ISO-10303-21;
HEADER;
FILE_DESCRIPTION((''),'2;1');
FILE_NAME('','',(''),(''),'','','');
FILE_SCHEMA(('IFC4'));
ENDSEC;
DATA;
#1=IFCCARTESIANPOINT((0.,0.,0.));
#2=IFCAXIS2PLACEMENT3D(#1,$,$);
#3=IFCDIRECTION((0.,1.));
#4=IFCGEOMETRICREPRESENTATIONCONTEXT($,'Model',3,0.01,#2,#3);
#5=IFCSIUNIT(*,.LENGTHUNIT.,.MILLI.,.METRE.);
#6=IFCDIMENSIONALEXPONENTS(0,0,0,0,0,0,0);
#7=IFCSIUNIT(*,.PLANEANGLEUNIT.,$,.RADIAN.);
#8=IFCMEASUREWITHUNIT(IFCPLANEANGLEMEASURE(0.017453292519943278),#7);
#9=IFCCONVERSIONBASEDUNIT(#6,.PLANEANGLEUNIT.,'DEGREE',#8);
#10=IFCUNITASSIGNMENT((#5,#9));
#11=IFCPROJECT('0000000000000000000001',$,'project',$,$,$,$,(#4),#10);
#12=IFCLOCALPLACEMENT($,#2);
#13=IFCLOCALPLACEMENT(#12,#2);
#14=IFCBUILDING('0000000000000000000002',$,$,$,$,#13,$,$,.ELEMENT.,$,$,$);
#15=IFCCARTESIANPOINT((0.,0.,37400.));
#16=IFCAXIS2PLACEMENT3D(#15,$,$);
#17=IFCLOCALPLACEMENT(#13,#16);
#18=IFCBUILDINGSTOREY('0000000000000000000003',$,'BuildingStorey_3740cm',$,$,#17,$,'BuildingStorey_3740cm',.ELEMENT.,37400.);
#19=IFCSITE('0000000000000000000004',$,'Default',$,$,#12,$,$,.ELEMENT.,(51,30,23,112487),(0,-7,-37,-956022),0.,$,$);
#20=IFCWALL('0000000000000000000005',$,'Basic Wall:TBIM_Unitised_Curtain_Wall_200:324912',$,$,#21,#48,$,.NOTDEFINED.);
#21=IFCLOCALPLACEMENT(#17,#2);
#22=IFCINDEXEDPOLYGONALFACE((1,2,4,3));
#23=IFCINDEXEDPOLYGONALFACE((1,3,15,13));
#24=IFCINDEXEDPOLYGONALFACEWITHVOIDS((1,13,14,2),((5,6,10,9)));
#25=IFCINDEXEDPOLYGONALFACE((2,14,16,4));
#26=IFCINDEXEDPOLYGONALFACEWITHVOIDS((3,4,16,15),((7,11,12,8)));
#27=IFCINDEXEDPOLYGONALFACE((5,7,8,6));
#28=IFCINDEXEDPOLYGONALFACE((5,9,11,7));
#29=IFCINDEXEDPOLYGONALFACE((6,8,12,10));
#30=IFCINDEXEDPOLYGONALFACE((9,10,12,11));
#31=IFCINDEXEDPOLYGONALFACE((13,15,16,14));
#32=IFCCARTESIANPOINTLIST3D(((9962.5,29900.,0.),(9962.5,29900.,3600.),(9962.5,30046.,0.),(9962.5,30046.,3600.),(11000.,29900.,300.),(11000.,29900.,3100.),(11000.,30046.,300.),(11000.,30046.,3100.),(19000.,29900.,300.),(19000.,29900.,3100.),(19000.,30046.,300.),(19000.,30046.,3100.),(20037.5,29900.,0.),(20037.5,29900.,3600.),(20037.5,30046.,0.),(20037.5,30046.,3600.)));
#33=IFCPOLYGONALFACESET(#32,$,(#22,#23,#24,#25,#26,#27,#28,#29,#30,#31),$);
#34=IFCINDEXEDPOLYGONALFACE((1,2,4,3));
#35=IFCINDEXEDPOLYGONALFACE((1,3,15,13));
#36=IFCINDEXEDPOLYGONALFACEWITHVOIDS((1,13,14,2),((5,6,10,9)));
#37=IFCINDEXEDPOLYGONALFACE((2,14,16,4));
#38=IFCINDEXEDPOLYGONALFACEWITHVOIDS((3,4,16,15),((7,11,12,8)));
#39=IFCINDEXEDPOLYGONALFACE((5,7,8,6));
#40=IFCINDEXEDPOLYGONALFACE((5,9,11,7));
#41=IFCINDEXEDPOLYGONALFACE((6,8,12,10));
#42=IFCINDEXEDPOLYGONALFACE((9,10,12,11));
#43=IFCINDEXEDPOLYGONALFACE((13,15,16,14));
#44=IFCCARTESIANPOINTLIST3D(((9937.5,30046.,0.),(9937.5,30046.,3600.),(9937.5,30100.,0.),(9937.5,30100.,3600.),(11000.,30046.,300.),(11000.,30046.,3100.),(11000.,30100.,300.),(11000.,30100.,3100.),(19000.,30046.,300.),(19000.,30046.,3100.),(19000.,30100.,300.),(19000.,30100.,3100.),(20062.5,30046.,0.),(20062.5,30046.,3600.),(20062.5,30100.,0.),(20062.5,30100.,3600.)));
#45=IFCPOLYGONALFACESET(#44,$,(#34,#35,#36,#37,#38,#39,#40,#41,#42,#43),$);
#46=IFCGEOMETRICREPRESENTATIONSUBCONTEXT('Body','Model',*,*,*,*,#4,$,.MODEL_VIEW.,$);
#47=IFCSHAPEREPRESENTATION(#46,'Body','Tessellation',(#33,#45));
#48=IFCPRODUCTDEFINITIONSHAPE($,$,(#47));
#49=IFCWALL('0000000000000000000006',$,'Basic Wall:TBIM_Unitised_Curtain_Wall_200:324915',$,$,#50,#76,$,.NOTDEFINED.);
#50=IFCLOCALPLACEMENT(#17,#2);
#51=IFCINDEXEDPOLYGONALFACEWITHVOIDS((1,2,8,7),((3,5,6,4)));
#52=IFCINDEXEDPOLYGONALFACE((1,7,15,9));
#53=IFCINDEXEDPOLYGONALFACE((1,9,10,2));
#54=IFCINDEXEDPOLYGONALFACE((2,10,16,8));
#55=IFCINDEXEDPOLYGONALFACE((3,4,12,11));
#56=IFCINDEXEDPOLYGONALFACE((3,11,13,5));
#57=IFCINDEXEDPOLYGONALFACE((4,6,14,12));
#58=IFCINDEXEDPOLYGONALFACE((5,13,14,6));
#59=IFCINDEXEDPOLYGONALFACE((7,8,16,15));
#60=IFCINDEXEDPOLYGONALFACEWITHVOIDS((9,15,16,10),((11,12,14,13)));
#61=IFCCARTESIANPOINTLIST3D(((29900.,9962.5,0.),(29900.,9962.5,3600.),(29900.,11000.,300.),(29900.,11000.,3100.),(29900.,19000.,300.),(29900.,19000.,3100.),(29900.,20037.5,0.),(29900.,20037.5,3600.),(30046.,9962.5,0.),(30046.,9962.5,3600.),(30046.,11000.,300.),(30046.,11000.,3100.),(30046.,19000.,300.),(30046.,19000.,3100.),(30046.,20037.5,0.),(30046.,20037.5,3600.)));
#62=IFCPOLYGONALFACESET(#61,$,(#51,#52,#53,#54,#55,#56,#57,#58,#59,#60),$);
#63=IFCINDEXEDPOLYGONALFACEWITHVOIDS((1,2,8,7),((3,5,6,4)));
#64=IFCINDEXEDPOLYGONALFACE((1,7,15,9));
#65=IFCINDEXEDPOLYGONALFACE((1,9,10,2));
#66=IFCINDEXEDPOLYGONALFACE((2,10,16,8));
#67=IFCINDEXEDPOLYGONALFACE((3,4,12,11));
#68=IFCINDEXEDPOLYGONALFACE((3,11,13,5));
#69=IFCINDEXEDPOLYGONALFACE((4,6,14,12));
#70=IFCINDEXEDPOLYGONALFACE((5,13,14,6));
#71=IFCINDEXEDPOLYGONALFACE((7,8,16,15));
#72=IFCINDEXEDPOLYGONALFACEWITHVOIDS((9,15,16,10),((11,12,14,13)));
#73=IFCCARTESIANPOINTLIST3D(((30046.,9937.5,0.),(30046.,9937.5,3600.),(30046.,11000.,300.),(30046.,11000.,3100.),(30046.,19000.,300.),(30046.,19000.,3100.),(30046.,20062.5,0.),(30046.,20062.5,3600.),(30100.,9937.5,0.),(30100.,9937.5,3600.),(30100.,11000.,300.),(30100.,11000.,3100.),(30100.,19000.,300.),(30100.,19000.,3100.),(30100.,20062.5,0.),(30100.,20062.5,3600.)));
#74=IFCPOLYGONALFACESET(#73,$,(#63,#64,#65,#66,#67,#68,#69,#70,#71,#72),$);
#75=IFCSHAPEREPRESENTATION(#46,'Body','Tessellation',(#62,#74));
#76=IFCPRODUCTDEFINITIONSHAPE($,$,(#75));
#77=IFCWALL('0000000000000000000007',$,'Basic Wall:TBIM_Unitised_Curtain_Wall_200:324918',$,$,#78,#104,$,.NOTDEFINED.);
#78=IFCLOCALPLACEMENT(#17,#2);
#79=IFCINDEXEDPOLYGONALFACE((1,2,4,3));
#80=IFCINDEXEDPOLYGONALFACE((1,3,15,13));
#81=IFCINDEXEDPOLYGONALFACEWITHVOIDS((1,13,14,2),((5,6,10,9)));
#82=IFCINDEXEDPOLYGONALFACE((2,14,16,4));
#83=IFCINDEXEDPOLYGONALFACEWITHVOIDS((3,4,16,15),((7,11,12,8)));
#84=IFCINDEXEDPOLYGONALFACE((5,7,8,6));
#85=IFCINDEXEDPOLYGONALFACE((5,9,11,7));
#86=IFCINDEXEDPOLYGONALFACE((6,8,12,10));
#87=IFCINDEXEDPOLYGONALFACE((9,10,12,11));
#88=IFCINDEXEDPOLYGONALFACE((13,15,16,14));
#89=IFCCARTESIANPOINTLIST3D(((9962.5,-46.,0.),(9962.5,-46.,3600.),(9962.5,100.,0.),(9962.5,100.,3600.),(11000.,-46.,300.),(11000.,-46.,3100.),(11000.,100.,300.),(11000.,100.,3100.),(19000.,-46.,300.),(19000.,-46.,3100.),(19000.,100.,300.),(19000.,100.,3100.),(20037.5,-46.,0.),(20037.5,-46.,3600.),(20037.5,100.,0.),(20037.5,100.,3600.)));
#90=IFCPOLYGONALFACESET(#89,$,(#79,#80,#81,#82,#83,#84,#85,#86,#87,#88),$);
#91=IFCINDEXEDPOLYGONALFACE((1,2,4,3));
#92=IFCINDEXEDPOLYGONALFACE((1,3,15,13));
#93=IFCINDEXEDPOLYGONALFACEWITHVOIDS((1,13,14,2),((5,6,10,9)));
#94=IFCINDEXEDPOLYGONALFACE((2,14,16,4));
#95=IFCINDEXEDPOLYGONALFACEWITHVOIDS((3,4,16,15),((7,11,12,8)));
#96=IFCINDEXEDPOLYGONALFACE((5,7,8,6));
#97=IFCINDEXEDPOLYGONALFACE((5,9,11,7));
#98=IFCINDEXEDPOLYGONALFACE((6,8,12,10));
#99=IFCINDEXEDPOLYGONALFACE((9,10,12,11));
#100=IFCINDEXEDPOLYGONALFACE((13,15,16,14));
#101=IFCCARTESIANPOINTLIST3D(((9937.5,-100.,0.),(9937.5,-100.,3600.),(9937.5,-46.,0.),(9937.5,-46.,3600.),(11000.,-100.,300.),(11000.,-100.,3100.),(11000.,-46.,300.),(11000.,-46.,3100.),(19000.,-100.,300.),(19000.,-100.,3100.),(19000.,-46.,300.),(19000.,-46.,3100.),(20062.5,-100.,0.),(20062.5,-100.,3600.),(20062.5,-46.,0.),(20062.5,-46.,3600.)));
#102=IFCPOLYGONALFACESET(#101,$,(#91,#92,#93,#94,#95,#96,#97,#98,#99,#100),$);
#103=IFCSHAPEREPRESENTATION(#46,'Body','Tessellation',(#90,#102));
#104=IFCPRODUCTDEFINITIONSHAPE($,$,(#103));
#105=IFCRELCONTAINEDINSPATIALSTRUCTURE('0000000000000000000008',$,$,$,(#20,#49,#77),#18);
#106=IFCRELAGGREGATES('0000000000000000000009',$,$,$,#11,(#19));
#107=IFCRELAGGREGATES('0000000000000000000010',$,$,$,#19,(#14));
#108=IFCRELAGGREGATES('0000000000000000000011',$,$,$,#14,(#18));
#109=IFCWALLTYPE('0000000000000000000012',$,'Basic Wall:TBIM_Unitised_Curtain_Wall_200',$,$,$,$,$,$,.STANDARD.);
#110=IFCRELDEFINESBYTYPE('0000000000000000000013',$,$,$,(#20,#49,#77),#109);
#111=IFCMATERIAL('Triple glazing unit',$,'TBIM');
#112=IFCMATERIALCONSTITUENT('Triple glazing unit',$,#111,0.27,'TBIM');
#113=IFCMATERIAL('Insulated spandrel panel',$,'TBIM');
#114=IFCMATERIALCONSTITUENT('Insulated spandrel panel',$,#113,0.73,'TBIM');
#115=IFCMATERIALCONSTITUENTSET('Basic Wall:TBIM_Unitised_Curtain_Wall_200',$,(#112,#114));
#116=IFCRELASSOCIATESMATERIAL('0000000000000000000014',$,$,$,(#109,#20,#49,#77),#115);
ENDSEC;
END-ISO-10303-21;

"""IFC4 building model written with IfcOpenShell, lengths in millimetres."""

from ifc_helpers import new_model, entity, si_unit, converted_unit, direction, frame, origin, place, context, subcontext, project, spatial, indexed_curve, outline, extrude, material, constituent, constituent_set, type_object, element, save


model = new_model("IFC4")

# Units and contexts
model_context = context("Model", 3, precision=0.01, world=origin(), true_north=direction((0.0, 1.0)))
body_context = subcontext(model_context, "Body", "Model", "MODEL_VIEW")
ifc_project = project(units=[si_unit("LENGTHUNIT", "METRE", prefix="MILLI"), converted_unit("PLANEANGLEUNIT", "DEGREE", entity("IfcPlaneAngleMeasure", 0.017453292519943278), si_unit("PLANEANGLEUNIT", "RADIAN"), dimensions=[0, 0, 0, 0, 0, 0, 0])], contexts=[model_context])

# Site, building, storey
site_placement = place(None, origin())
site = spatial("IfcSite", under=ifc_project, at=site_placement, Name="Default", CompositionType="ELEMENT", RefLatitude=(51, 30, 23, 112487), RefLongitude=(0, -7, -37, -956022), RefElevation=0.0)
building_placement = place(site_placement, origin())
building = spatial("IfcBuilding", under=site, at=building_placement, CompositionType="ELEMENT")
storey_placement = place(building_placement, frame((0.0, 0.0, 37400.0)))
storey = spatial("IfcBuildingStorey", under=building, at=storey_placement, Name="BuildingStorey_3740cm", LongName="BuildingStorey_3740cm", CompositionType="ELEMENT", Elevation=37400.0)

# Walls, openings
ifc_material_1 = material(Name="Triple glazing unit", Category="TBIM")
ifc_constituent_1 = constituent(ifc_material_1, Name="Triple glazing unit", Category="TBIM", fraction=0.27)
ifc_material_2 = material(Name="Insulated spandrel panel", Category="TBIM")
ifc_constituent_2 = constituent(ifc_material_2, Name="Insulated spandrel panel", Category="TBIM", fraction=0.73)
ifc_constituent_set_1 = constituent_set(constituents=[ifc_constituent_1, ifc_constituent_2], Name="Basic Wall:TBIM_Unitised_Curtain_Wall_200")
wall_type_1 = type_object("IfcWallType", Name="Basic Wall:TBIM_Unitised_Curtain_Wall_200", PredefinedType="STANDARD", material=ifc_constituent_set_1)
wall_1_placement = place(storey_placement, frame((9937.5, 30000.0, 0.0)))
wall_1 = element("IfcWall", 1, at=wall_1_placement, inside=storey, type_object=wall_type_1, material=ifc_constituent_set_1, Name="Basic Wall:TBIM_Unitised_Curtain_Wall_200:324912", PredefinedType="NOTDEFINED", context=body_context, shape_type="SweptSolid", body=[
    extrude(outline(indexed_curve([(-1800.0, -5037.5), (1800.0, -5037.5), (1800.0, -4937.5), (1800.0, 4937.5), (1800.0, 5037.5), (-1800.0, 5037.5), (-1800.0, 4937.5), (-1800.0, -4937.5), (-1800.0, -5037.5)], self_intersect=False), holes=[indexed_curve([(1300.0, -4000.0), (-1500.0, -4000.0), (-1500.0, 4000.0), (1300.0, 4000.0), (1300.0, -4000.0)], self_intersect=False)]), frame((5062.5, -100.0, 1800.0), z_axis=(0.0, 1.0, 0.0), x_axis=(0.0, 0.0, 1.0)), (0.0, 0.0, 1.0), 146.0),
    extrude(outline(indexed_curve([(-1800.0, -5062.5), (1800.0, -5062.5), (1800.0, 5062.5), (-1800.0, 5062.5), (-1800.0, -5062.5)], self_intersect=False), holes=[indexed_curve([(-1500.0, -4000.0), (-1500.0, 4000.0), (1300.0, 4000.0), (1300.0, -4000.0), (-1500.0, -4000.0)], self_intersect=False)]), frame((5062.5, 46.0, 1800.0), z_axis=(0.0, 1.0, 0.0), x_axis=(0.0, 0.0, 1.0)), (0.0, 0.0, 1.0), 54.0),
])
opening_1_placement = place(wall_1_placement, frame((1062.5, -100.0, 300.0)))
element("IfcOpeningElement", 2, at=opening_1_placement, cuts=wall_1, PredefinedType="OPENING", context=body_context, shape_type="SweptSolid", body=[
    extrude(outline(indexed_curve([(2800.0, 0.0), (2800.0, 8000.0), (0.0, 8000.0), (0.0, 0.0), (2800.0, 0.0)], self_intersect=False)), frame((0.0, 0.0, 0.0), z_axis=(0.0, 1.0, 0.0), x_axis=(0.0, 0.0, 1.0)), (0.0, 0.0, 1.0), 200.0),
])
wall_2_placement = place(storey_placement, frame((30000.0, 9937.5, 0.0), z_axis=(0.0, 0.0, 1.0), x_axis=(0.0, 1.0, 0.0)))
wall_2 = element("IfcWall", 3, at=wall_2_placement, inside=storey, type_object=wall_type_1, material=ifc_constituent_set_1, Name="Basic Wall:TBIM_Unitised_Curtain_Wall_200:324915", PredefinedType="NOTDEFINED", context=body_context, shape_type="SweptSolid", body=[
    extrude(outline(indexed_curve([(-5037.5, -1800.0), (-4937.5, -1800.0), (4937.5, -1800.0), (5037.5, -1800.0), (5037.5, 1800.0), (4937.5, 1800.0), (-4937.5, 1800.0), (-5037.5, 1800.0), (-5037.5, -1800.0)], self_intersect=False), holes=[indexed_curve([(-4000.0, 1300.0), (4000.0, 1300.0), (4000.0, -1500.0), (-4000.0, -1500.0), (-4000.0, 1300.0)], self_intersect=False)]), frame((5062.5, 100.0, 1800.0), z_axis=(0.0, -1.0, 0.0), x_axis=(1.0, 0.0, 0.0)), (0.0, 0.0, 1.0), 146.0),
    extrude(outline(indexed_curve([(-1800.0, -5062.5), (1800.0, -5062.5), (1800.0, 5062.5), (-1800.0, 5062.5), (-1800.0, -5062.5)], self_intersect=False), holes=[indexed_curve([(1300.0, 4000.0), (1300.0, -4000.0), (-1500.0, -4000.0), (-1500.0, 4000.0), (1300.0, 4000.0)], self_intersect=False)]), frame((5062.5, -46.0, 1800.0), z_axis=(0.0, -1.0, 0.0), x_axis=(0.0, 0.0, 1.0)), (0.0, 0.0, 1.0), 54.0),
])
opening_2_placement = place(wall_2_placement, frame((1062.5, -100.0, 300.0)))
element("IfcOpeningElement", 4, at=opening_2_placement, cuts=wall_2, PredefinedType="OPENING", context=body_context, shape_type="SweptSolid", body=[
    extrude(outline(indexed_curve([(2800.0, 0.0), (2800.0, 8000.0), (0.0, 8000.0), (0.0, 0.0), (2800.0, 0.0)], self_intersect=False)), frame((0.0, 0.0, 0.0), z_axis=(0.0, 1.0, 0.0), x_axis=(0.0, 0.0, 1.0)), (0.0, 0.0, 1.0), 200.0),
])
wall_3_placement = place(storey_placement, frame((9937.5, 0.0, 0.0)))
wall_3 = element("IfcWall", 5, at=wall_3_placement, inside=storey, type_object=wall_type_1, material=ifc_constituent_set_1, Name="Basic Wall:TBIM_Unitised_Curtain_Wall_200:324918", PredefinedType="NOTDEFINED", context=body_context, shape_type="SweptSolid", body=[
    extrude(outline(indexed_curve([(-1800.0, -5037.5), (1800.0, -5037.5), (1800.0, 5037.5), (-1800.0, 5037.5), (-1800.0, -5037.5)], self_intersect=False), holes=[indexed_curve([(-1500.0, -4000.0), (-1500.0, 4000.0), (1300.0, 4000.0), (1300.0, -4000.0), (-1500.0, -4000.0)], self_intersect=False)]), frame((5062.5, -46.0, 1800.0), z_axis=(0.0, 1.0, 0.0), x_axis=(0.0, 0.0, 1.0)), (0.0, 0.0, 1.0), 146.0),
    extrude(outline(indexed_curve([(-1800.0, -5062.5), (1800.0, -5062.5), (1800.0, 5062.5), (-1800.0, 5062.5), (-1800.0, -5062.5)], self_intersect=False), holes=[indexed_curve([(1300.0, -4000.0), (-1500.0, -4000.0), (-1500.0, 4000.0), (1300.0, 4000.0), (1300.0, -4000.0)], self_intersect=False)]), frame((5062.5, -100.0, 1800.0), z_axis=(0.0, 1.0, 0.0), x_axis=(0.0, 0.0, 1.0)), (0.0, 0.0, 1.0), 54.0),
])
opening_3_placement = place(wall_3_placement, frame((1062.5, -100.0, 300.0)))
element("IfcOpeningElement", 6, at=opening_3_placement, cuts=wall_3, PredefinedType="OPENING", context=body_context, shape_type="SweptSolid", body=[
    extrude(outline(indexed_curve([(2800.0, 0.0), (2800.0, 8000.0), (0.0, 8000.0), (0.0, 0.0), (2800.0, 0.0)], self_intersect=False)), frame((0.0, 0.0, 0.0), z_axis=(0.0, 1.0, 0.0), x_axis=(0.0, 0.0, 1.0)), (0.0, 0.0, 1.0), 200.0),
])

save(model, "model.ifc")
